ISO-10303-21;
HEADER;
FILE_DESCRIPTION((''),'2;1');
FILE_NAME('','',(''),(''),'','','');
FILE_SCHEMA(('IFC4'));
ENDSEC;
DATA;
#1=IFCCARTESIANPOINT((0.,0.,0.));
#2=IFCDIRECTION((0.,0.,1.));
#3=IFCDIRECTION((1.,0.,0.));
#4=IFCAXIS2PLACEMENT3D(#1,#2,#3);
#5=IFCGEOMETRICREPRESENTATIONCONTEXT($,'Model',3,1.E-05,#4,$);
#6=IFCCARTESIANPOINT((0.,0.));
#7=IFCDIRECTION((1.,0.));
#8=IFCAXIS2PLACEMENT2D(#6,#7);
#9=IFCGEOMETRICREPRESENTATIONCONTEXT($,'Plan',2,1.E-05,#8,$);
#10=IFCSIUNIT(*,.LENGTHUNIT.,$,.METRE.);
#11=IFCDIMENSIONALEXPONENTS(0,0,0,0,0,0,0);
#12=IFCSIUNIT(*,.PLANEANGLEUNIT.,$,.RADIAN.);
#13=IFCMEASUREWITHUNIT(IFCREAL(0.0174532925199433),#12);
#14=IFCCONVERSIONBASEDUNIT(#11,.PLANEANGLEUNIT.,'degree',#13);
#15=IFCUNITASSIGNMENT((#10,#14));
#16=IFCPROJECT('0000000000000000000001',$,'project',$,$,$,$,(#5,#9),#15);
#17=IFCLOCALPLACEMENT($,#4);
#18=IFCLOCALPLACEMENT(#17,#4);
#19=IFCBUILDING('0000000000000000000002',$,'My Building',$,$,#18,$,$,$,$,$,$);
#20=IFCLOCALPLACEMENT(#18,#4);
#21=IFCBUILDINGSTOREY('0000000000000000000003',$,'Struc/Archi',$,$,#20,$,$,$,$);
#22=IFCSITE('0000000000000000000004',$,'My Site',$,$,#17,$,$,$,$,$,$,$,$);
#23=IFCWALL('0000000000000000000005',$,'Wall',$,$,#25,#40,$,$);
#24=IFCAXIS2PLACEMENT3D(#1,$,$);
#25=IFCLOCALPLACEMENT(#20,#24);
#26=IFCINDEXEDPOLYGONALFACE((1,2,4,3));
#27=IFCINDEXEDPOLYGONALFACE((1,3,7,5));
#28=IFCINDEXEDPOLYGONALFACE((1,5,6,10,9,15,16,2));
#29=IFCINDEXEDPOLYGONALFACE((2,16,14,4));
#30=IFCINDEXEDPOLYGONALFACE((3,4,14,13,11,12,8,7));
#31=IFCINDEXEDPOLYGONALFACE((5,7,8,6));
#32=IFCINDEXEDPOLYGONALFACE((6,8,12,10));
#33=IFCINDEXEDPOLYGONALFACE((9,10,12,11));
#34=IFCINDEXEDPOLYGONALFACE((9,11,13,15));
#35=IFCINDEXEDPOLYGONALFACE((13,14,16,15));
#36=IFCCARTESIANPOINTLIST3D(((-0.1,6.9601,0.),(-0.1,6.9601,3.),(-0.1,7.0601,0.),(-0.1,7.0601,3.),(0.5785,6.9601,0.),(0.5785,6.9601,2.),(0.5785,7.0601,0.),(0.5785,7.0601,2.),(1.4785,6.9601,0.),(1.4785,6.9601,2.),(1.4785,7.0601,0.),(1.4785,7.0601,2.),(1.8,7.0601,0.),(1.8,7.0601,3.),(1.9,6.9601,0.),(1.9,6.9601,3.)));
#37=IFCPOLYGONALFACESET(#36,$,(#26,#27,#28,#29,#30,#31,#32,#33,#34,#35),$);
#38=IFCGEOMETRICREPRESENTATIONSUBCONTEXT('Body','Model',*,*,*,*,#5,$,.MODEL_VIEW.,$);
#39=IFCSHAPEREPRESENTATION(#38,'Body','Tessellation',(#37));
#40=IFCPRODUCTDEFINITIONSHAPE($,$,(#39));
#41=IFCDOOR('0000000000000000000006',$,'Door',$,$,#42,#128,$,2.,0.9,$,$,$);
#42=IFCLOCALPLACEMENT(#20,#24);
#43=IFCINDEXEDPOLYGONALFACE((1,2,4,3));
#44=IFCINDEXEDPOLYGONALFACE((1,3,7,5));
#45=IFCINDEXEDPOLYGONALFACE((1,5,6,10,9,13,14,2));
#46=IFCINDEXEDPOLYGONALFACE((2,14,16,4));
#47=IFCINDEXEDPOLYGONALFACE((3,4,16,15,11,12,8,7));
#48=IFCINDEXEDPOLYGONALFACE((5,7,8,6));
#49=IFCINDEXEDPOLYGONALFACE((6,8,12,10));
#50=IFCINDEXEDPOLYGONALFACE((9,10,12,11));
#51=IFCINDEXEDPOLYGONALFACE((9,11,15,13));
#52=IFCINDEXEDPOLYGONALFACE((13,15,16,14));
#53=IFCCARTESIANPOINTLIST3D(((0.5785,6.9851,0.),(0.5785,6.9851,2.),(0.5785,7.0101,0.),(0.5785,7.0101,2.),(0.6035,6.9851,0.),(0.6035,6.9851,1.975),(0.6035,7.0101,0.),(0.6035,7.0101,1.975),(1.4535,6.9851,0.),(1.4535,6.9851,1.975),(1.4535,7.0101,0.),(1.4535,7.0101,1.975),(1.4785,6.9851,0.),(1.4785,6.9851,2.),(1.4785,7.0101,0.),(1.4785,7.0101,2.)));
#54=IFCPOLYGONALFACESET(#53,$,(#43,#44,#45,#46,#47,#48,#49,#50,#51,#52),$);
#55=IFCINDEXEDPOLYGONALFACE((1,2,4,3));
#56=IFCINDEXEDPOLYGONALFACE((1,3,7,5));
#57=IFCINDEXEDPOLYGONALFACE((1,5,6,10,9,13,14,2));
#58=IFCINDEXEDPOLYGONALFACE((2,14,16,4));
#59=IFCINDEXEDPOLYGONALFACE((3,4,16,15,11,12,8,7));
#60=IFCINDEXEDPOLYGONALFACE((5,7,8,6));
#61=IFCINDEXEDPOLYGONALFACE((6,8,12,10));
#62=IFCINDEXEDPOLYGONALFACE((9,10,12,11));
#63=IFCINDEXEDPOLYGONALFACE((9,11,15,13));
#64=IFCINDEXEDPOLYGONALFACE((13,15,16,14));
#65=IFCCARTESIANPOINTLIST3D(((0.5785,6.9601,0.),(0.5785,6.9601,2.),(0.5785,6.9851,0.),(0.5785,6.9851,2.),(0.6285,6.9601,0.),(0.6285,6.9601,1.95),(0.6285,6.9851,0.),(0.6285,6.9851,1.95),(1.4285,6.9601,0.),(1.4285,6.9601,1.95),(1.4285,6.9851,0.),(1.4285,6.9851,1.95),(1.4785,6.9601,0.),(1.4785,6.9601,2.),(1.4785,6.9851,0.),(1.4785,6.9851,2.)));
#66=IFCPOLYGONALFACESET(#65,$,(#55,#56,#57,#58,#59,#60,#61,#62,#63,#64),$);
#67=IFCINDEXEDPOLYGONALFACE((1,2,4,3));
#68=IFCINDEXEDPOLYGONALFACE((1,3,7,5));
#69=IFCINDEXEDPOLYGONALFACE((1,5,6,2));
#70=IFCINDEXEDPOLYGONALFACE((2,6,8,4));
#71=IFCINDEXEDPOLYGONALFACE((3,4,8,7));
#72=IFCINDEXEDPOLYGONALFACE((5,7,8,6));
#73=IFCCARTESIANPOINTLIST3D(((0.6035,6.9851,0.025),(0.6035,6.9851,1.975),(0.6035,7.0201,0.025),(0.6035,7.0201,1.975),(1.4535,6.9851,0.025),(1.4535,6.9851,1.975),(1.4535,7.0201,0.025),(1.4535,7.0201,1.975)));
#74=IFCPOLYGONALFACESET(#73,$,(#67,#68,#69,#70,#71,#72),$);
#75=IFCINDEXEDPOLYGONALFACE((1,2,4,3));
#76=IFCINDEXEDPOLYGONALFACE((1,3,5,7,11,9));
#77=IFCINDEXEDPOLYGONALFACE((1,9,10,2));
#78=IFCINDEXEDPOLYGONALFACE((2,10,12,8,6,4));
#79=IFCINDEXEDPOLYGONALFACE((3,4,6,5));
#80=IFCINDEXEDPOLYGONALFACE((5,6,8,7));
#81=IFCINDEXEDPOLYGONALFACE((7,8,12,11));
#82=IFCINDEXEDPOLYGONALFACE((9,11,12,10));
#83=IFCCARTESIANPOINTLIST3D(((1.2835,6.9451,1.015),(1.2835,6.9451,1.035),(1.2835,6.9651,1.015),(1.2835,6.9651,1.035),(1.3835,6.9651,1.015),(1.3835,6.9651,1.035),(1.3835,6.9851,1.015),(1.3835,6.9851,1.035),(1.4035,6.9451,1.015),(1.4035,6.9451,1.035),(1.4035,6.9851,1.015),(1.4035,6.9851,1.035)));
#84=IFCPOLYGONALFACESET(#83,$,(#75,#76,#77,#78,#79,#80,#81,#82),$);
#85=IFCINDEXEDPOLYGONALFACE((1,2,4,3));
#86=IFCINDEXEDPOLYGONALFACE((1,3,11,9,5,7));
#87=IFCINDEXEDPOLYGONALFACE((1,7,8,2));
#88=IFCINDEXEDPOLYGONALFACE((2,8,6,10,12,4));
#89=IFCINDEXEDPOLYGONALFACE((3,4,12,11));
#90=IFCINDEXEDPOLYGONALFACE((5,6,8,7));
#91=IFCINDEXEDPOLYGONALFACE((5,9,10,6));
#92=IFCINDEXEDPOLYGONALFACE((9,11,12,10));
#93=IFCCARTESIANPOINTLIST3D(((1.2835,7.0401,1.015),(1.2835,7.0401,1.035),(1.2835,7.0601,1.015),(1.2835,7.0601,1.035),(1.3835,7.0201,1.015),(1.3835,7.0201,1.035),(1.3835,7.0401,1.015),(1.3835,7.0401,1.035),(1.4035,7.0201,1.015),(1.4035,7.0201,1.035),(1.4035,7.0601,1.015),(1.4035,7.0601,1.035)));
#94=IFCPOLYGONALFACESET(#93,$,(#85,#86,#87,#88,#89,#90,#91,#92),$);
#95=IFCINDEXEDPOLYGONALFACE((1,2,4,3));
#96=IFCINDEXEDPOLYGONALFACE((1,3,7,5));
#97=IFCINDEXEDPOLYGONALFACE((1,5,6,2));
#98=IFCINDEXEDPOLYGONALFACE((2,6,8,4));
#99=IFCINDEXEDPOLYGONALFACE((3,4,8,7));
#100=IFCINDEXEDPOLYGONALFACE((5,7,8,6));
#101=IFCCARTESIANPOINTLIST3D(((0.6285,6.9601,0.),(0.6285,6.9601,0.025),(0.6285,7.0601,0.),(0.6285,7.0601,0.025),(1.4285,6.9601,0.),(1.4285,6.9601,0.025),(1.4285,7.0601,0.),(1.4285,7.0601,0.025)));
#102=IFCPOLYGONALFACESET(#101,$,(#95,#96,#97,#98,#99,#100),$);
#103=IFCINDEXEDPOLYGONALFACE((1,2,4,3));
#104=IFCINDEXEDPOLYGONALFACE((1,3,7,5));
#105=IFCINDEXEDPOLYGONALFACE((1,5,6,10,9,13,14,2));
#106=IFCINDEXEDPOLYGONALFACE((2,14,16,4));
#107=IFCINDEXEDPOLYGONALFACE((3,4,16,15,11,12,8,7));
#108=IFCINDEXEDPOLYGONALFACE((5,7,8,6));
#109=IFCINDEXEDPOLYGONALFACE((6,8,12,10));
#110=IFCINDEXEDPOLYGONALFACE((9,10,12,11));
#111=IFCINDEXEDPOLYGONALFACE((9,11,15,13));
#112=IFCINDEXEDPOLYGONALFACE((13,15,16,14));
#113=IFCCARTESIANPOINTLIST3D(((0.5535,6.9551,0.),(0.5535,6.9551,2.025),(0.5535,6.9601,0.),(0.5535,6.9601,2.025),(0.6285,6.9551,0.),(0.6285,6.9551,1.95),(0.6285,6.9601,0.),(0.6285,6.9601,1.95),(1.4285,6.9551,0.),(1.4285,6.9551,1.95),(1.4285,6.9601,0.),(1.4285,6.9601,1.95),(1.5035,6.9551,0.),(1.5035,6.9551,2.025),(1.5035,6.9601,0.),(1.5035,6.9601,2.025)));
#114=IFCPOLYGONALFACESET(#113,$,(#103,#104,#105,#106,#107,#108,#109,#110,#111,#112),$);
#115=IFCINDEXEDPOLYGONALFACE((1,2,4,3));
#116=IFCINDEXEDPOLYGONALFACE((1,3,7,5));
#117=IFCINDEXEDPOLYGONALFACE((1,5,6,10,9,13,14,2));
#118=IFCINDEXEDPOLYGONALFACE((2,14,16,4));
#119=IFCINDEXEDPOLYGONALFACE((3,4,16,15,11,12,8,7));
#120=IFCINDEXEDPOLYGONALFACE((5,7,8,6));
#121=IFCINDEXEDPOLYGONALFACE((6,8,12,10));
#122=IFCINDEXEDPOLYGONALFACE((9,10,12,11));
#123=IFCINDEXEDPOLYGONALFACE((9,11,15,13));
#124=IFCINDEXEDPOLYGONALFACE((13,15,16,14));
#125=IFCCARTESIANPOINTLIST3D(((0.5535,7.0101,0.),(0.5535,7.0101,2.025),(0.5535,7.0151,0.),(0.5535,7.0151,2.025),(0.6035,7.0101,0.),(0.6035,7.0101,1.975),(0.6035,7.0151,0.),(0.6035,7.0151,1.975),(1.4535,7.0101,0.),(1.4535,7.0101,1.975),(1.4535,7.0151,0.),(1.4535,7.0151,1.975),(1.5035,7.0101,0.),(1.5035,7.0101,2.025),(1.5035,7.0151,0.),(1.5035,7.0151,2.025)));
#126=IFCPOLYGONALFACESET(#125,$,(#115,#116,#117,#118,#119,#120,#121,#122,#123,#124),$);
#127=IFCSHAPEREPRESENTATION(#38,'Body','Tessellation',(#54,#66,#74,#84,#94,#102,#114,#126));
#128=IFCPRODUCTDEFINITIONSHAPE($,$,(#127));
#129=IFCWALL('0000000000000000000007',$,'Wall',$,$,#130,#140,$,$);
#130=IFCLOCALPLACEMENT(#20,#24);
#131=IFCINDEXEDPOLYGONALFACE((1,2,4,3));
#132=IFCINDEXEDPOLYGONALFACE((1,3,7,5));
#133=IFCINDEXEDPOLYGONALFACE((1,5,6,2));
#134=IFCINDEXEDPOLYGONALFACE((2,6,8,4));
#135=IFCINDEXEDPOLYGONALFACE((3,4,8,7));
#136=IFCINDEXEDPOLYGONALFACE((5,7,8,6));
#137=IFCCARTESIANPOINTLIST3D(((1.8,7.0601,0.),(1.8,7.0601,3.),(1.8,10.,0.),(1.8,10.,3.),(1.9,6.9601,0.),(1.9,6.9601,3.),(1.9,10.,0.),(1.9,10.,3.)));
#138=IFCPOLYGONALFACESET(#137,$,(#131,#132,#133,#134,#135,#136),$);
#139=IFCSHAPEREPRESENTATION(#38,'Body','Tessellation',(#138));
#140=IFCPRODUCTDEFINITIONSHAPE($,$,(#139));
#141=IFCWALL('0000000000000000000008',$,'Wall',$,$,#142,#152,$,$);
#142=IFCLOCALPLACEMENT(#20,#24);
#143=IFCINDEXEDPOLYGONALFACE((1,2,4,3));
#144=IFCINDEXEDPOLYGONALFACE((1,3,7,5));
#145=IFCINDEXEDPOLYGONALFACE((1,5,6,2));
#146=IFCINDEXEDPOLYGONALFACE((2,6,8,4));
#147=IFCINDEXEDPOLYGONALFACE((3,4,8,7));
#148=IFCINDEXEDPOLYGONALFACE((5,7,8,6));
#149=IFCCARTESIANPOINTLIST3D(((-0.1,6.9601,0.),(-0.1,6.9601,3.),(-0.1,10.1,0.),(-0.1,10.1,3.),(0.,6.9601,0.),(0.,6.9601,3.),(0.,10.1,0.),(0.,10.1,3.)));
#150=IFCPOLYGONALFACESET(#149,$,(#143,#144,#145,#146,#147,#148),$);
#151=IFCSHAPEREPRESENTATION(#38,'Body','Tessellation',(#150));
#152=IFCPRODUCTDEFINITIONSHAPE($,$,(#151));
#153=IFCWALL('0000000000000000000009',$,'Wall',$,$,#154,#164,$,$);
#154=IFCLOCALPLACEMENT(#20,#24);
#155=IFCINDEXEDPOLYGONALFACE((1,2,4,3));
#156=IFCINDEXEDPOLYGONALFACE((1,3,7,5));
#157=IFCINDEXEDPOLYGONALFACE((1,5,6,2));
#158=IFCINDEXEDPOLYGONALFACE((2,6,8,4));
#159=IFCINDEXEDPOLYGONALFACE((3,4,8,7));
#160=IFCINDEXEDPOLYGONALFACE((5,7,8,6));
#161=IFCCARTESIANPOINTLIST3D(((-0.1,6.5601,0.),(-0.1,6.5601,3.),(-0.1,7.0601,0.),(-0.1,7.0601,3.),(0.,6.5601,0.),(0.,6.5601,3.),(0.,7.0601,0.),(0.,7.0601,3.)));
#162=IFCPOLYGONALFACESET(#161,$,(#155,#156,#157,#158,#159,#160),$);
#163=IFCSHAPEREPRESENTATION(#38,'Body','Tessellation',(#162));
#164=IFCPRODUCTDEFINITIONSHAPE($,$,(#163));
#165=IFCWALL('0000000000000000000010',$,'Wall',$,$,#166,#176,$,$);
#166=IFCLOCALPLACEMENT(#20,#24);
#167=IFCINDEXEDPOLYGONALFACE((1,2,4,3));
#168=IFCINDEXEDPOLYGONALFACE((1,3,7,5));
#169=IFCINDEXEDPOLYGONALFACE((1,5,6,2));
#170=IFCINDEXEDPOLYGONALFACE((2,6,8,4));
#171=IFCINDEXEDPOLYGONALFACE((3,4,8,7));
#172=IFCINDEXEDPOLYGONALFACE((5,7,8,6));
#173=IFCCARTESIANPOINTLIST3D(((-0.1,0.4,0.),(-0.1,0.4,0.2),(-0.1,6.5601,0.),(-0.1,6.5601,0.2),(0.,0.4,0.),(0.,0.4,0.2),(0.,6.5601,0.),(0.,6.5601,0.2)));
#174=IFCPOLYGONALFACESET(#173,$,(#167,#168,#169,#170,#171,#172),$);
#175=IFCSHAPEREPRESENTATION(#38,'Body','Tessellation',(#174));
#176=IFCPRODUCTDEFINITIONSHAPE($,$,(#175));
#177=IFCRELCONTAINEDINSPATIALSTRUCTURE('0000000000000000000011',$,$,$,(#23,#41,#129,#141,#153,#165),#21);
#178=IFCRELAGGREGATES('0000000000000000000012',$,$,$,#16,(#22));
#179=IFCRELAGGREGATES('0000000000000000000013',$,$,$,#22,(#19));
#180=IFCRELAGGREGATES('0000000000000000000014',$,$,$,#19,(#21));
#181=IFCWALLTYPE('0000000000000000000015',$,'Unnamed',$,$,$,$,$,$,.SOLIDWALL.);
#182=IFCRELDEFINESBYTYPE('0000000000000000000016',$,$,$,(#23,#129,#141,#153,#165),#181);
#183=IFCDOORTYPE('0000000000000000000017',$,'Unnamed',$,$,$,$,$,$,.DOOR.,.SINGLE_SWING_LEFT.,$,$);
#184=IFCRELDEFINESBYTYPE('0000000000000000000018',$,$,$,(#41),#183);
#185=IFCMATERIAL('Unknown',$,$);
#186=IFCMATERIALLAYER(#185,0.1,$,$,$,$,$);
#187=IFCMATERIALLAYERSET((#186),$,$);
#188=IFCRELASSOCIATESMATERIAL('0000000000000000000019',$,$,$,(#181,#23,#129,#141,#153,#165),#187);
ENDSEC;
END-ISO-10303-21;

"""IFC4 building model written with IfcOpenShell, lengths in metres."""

from ifc_helpers import new_model, entity, si_unit, converted_unit, frame, origin_with_axes, origin_2d_with_axis, place, context, subcontext, project, spatial, line, indexed_curve, outline, extrude, shape, source, transform, mapped, material, layer, layer_set, layer_usage, type_object, type_shapes, element, fill, save


model = new_model("IFC4")

# Units and contexts
model_context = context("Model", 3, precision=1e-05, world=origin_with_axes())
plan_context = context("Plan", 2, precision=1e-05, world=origin_2d_with_axis())
body_context_1 = subcontext(model_context, "Body", "Model", "MODEL_VIEW")
body_context_2 = subcontext(plan_context, "Body", "Plan", "PLAN_VIEW")
ifc_project = project(units=[si_unit("LENGTHUNIT", "METRE"), converted_unit("PLANEANGLEUNIT", "degree", entity("IfcReal", 0.0174532925199433), si_unit("PLANEANGLEUNIT", "RADIAN"), dimensions=[0, 0, 0, 0, 0, 0, 0])], contexts=[model_context, plan_context])

# Site, building, storey
site_placement = place(None, origin_with_axes())
site = spatial("IfcSite", under=ifc_project, at=site_placement, Name="My Site")
building_placement = place(site_placement, origin_with_axes())
building = spatial("IfcBuilding", under=site, at=building_placement, Name="My Building")
storey_placement = place(building_placement, origin_with_axes())
storey = spatial("IfcBuildingStorey", under=building, at=storey_placement, Name="Struc/Archi")

# Shared definitions
ifc_material = material(Name="Unknown")

# Wall, opening, door
ifc_layer_1 = layer(ifc_material, 0.1)
ifc_layer_set_1 = layer_set([ifc_layer_1])
wall_type = type_object("IfcWallType", Name="Unnamed", PredefinedType="SOLIDWALL", material=ifc_layer_set_1)
shared_shape_1 = source(origin_with_axes(), body_context_1, "Body", "SweptSolid", [
    extrude(outline(indexed_curve([(0.0, 0.0), (0.9, 0.0), (0.9, 2.0), (0.0, 2.0)], segments=[line(1, 2, 3, 4, 1)])), frame((0.0, -0.6, 0.0), z_axis=(0.0, -1.0, 0.0), x_axis=(1.0, 0.0, 0.0)), (0.0, 0.0, -1.0), 1.2),
])
door_type = type_object("IfcDoorType", Name="Unnamed", OperationType="SINGLE_SWING_LEFT", PredefinedType="DOOR")
shared_shape_2 = source(origin_with_axes(), body_context_1, "Body", "SweptSolid", [
    extrude(outline(indexed_curve([(0.0, 0.0), (0.0, 2.0), (0.9, 2.0), (0.9, 0.0), (0.875, 0.0), (0.875, 1.975), (0.025, 1.975), (0.025, 0.0)], segments=[line(1, 2, 3, 4, 5, 6, 7, 8, 1)])), frame((0.0, 0.025, 0.0), z_axis=(0.0, -1.0, 0.0), x_axis=(1.0, 0.0, 0.0)), (0.0, 0.0, -1.0), 0.025),
    extrude(outline(indexed_curve([(0.0, 0.0), (0.0, 2.0), (0.9, 2.0), (0.9, 0.0), (0.85, 0.0), (0.85, 1.95), (0.05, 1.95), (0.05, 0.0)], segments=[line(1, 2, 3, 4, 5, 6, 7, 8, 1)])), frame((0.0, 0.0, 0.0), z_axis=(0.0, -1.0, 0.0), x_axis=(1.0, 0.0, 0.0)), (0.0, 0.0, -1.0), 0.025),
    extrude(outline(indexed_curve([(0.0, 0.0), (0.85, 0.0), (0.85, 0.035), (0.0, 0.035)], segments=[line(1, 2, 3, 4, 1)])), frame((0.025, 0.025, 0.025), z_axis=(0.0, 0.0, 1.0), x_axis=(1.0, 0.0, 0.0)), (0.0, 0.0, 1.0), 1.95),
    extrude(outline(indexed_curve([(0.0, 0.0), (0.0, -0.04), (-0.12, -0.04), (-0.12, -0.02), (-0.02, -0.02), (-0.02, 0.0)], segments=[line(1, 2, 3, 4, 5, 6, 1)])), frame((0.825, 0.025, 1.015), z_axis=(0.0, 0.0, 1.0), x_axis=(1.0, 0.0, 0.0)), (0.0, 0.0, 1.0), 0.02),
    extrude(outline(indexed_curve([(0.0, 0.0), (0.0, 0.04), (-0.12, 0.04), (-0.12, 0.02), (-0.02, 0.02), (-0.02, 0.0)], segments=[line(1, 2, 3, 4, 5, 6, 1)])), frame((0.825, 0.06, 1.015), z_axis=(0.0, 0.0, 1.0), x_axis=(1.0, 0.0, 0.0)), (0.0, 0.0, 1.0), 0.02),
    extrude(outline(indexed_curve([(0.0, 0.0), (0.8, 0.0), (0.8, 0.1), (0.0, 0.1)], segments=[line(1, 2, 3, 4, 1)])), frame((0.05, 0.0, 0.0), z_axis=(0.0, 0.0, 1.0), x_axis=(1.0, 0.0, 0.0)), (0.0, 0.0, 1.0), 0.025),
    extrude(outline(indexed_curve([(0.0, 0.0), (0.0, 2.025), (0.95, 2.025), (0.95, 0.0), (0.875, 0.0), (0.875, 1.95), (0.075, 1.95), (0.075, 0.0)], segments=[line(1, 2, 3, 4, 5, 6, 7, 8, 1)])), frame((-0.025, -0.005, 0.0), z_axis=(0.0, -1.0, 0.0), x_axis=(1.0, 0.0, 0.0)), (0.0, 0.0, -1.0), 0.005),
    extrude(outline(indexed_curve([(0.0, 0.0), (0.0, 2.025), (0.95, 2.025), (0.95, 0.0), (0.9, 0.0), (0.9, 1.975), (0.05, 1.975), (0.05, 0.0)], segments=[line(1, 2, 3, 4, 5, 6, 7, 8, 1)])), frame((-0.025, 0.05, 0.0), z_axis=(0.0, -1.0, 0.0), x_axis=(1.0, 0.0, 0.0)), (0.0, 0.0, -1.0), 0.005),
])
shared_shape_3 = source(origin_with_axes(), body_context_2, "Body", "Curve2D", [
    entity("IfcIndexedPolyCurve", entity("IfcCartesianPointList2D", [[0.0, 0.0], [0.0, 0.05], [0.025, 0.05], [0.025, 0.025], [0.05, 0.025], [0.05, 0.0]]), [entity("IfcLineIndex", [1, 2, 3, 4, 5, 6, 1])]),
    entity("IfcIndexedPolyCurve", entity("IfcCartesianPointList2D", [[0.9, 0.0], [0.9, 0.05], [0.875, 0.05], [0.875, 0.025], [0.85, 0.025], [0.85, 0.0]]), [entity("IfcLineIndex", [1, 2, 3, 4, 5, 6, 1])]),
    entity("IfcTrimmedCurve", entity("IfcEllipse", entity("IfcAxis2Placement2D", entity("IfcCartesianPoint", [0.06, 0.05]), entity("IfcDirection", [1.0, 0.0])), 0.815, 0.85), [entity("IfcCartesianPoint", [0.875, 0.05])], [entity("IfcCartesianPoint", [0.06, 0.9])], True, "CARTESIAN"),
    entity("IfcIndexedPolyCurve", entity("IfcCartesianPointList2D", [[0.025, 0.05], [0.06, 0.05], [0.06, 0.9], [0.025, 0.9]]), [entity("IfcLineIndex", [1, 2, 3, 4, 1])]),
])
type_shapes(door_type, [shared_shape_2, shared_shape_3])
ifc_layer_usage_1 = layer_usage(ifc_layer_set_1, "AXIS2", "POSITIVE", 0.0)
wall_1_placement = place(storey_placement, frame((-0.1, 6.9601, 0.0), z_axis=(0.0, 0.0, 1.0), x_axis=(1.0, 0.0, 0.0)))
wall_1 = element("IfcWall", 1, at=wall_1_placement, inside=storey, type_object=wall_type, material=ifc_layer_usage_1, Name="Wall", context=body_context_1, shape_type="SweptSolid", body=[
    extrude(outline(indexed_curve([(0.0, 0.0), (0.0, 0.1), (1.9, 0.1), (2.0, 0.0)], segments=[line(1, 2, 3, 4, 1)])), origin_with_axes(), (0.0, 0.0, 1.0), 3.0),
])
opening_1_placement = place(wall_1_placement, frame((0.6785, 0.0, 0.0), z_axis=(0.0, 0.0, 1.0), x_axis=(1.0, 0.0, 0.0)))
opening_1 = element("IfcOpeningElement", 2, at=opening_1_placement, cuts=wall_1, PredefinedType="OPENING", context=body_context_1, shape_type="MappedRepresentation", body=[
    mapped(shared_shape_1, transform((0.0, 0.0, 0.0), x_axis=(1.0, 0.0, 0.0), y_axis=(0.0, 1.0, 0.0), z_axis=(0.0, 0.0, 1.0), scale=1.0)),
])
door_1_placement = place(opening_1_placement, origin_with_axes())
door_1 = element("IfcDoor", 3, at=door_1_placement, inside=storey, type_object=door_type, Name="Door", OverallHeight=2.0, OverallWidth=0.9, shapes=[
    shape(body_context_1, "Body", "MappedRepresentation", [mapped(shared_shape_2, transform((0.0, 0.0, 0.0), x_axis=(1.0, 0.0, 0.0), y_axis=(0.0, 1.0, 0.0), z_axis=(0.0, 0.0, 1.0), scale=1.0))]),
    shape(body_context_2, "Body", "MappedRepresentation", [mapped(shared_shape_3, transform((0.0, 0.0, 0.0), x_axis=(1.0, 0.0, 0.0), y_axis=(0.0, 1.0, 0.0), z_axis=(0.0, 0.0, 1.0), scale=1.0))]),
])
fill(opening_1, door_1)

# Walls
ifc_layer_usage_2 = layer_usage(ifc_layer_set_1, "AXIS2", "POSITIVE", 0.0)
wall_2_placement = place(storey_placement, frame((1.9, 6.9601, 0.0), z_axis=(0.0, 0.0, 1.0), x_axis=(0.0, 1.0, 0.0)))
element("IfcWall", 4, at=wall_2_placement, inside=storey, type_object=wall_type, material=ifc_layer_usage_2, Name="Wall", context=body_context_1, shape_type="SweptSolid", body=[
    extrude(outline(indexed_curve([(0.0, 0.0), (0.1, 0.1), (3.0399, 0.1), (3.0399, 0.0)], segments=[line(1, 2, 3, 4, 1)])), origin_with_axes(), (0.0, 0.0, 1.0), 3.0),
])
ifc_layer_usage_3 = layer_usage(ifc_layer_set_1, "AXIS2", "POSITIVE", 0.0)
wall_3_placement = place(storey_placement, frame((-0.1, 10.1, 0.0), z_axis=(0.0, 0.0, 1.0), x_axis=(0.0, -1.0, 0.0)))
element("IfcWall", 5, at=wall_3_placement, inside=storey, type_object=wall_type, material=ifc_layer_usage_3, Name="Wall", context=body_context_1, shape_type="SweptSolid", body=[
    extrude(outline(indexed_curve([(0.0, 0.0), (0.0, 0.1), (3.1399, 0.1), (3.1399, 0.0)], segments=[line(1, 2, 3, 4, 1)])), origin_with_axes(), (0.0, 0.0, 1.0), 3.0),
])
ifc_layer_usage_4 = layer_usage(ifc_layer_set_1, "AXIS2", "POSITIVE", 0.0)
wall_4_placement = place(storey_placement, frame((-0.1, 7.0601, 0.0), z_axis=(0.0, 0.0, 1.0), x_axis=(0.0, -1.0, 0.0)))
element("IfcWall", 6, at=wall_4_placement, inside=storey, type_object=wall_type, material=ifc_layer_usage_4, Name="Wall", context=body_context_1, shape_type="SweptSolid", body=[
    extrude(outline(indexed_curve([(0.0, 0.0), (0.0, 0.1), (0.5, 0.1), (0.5, 0.0)], segments=[line(1, 2, 3, 4, 1)])), origin_with_axes(), (0.0, 0.0, 1.0), 3.0),
])
ifc_layer_usage_5 = layer_usage(ifc_layer_set_1, "AXIS2", "POSITIVE", 0.0)
wall_5_placement = place(storey_placement, frame((-0.1, 6.5601, 0.0), z_axis=(0.0, 0.0, 1.0), x_axis=(0.0, -1.0, 0.0)))
element("IfcWall", 7, at=wall_5_placement, inside=storey, type_object=wall_type, material=ifc_layer_usage_5, Name="Wall", context=body_context_1, shape_type="SweptSolid", body=[
    extrude(outline(indexed_curve([(0.0, 0.0), (0.0, 0.1), (6.1601, 0.1), (6.1601, 0.0)], segments=[line(1, 2, 3, 4, 1)])), origin_with_axes(), (0.0, 0.0, 1.0), 0.2),
])

save(model, "model.ifc")
